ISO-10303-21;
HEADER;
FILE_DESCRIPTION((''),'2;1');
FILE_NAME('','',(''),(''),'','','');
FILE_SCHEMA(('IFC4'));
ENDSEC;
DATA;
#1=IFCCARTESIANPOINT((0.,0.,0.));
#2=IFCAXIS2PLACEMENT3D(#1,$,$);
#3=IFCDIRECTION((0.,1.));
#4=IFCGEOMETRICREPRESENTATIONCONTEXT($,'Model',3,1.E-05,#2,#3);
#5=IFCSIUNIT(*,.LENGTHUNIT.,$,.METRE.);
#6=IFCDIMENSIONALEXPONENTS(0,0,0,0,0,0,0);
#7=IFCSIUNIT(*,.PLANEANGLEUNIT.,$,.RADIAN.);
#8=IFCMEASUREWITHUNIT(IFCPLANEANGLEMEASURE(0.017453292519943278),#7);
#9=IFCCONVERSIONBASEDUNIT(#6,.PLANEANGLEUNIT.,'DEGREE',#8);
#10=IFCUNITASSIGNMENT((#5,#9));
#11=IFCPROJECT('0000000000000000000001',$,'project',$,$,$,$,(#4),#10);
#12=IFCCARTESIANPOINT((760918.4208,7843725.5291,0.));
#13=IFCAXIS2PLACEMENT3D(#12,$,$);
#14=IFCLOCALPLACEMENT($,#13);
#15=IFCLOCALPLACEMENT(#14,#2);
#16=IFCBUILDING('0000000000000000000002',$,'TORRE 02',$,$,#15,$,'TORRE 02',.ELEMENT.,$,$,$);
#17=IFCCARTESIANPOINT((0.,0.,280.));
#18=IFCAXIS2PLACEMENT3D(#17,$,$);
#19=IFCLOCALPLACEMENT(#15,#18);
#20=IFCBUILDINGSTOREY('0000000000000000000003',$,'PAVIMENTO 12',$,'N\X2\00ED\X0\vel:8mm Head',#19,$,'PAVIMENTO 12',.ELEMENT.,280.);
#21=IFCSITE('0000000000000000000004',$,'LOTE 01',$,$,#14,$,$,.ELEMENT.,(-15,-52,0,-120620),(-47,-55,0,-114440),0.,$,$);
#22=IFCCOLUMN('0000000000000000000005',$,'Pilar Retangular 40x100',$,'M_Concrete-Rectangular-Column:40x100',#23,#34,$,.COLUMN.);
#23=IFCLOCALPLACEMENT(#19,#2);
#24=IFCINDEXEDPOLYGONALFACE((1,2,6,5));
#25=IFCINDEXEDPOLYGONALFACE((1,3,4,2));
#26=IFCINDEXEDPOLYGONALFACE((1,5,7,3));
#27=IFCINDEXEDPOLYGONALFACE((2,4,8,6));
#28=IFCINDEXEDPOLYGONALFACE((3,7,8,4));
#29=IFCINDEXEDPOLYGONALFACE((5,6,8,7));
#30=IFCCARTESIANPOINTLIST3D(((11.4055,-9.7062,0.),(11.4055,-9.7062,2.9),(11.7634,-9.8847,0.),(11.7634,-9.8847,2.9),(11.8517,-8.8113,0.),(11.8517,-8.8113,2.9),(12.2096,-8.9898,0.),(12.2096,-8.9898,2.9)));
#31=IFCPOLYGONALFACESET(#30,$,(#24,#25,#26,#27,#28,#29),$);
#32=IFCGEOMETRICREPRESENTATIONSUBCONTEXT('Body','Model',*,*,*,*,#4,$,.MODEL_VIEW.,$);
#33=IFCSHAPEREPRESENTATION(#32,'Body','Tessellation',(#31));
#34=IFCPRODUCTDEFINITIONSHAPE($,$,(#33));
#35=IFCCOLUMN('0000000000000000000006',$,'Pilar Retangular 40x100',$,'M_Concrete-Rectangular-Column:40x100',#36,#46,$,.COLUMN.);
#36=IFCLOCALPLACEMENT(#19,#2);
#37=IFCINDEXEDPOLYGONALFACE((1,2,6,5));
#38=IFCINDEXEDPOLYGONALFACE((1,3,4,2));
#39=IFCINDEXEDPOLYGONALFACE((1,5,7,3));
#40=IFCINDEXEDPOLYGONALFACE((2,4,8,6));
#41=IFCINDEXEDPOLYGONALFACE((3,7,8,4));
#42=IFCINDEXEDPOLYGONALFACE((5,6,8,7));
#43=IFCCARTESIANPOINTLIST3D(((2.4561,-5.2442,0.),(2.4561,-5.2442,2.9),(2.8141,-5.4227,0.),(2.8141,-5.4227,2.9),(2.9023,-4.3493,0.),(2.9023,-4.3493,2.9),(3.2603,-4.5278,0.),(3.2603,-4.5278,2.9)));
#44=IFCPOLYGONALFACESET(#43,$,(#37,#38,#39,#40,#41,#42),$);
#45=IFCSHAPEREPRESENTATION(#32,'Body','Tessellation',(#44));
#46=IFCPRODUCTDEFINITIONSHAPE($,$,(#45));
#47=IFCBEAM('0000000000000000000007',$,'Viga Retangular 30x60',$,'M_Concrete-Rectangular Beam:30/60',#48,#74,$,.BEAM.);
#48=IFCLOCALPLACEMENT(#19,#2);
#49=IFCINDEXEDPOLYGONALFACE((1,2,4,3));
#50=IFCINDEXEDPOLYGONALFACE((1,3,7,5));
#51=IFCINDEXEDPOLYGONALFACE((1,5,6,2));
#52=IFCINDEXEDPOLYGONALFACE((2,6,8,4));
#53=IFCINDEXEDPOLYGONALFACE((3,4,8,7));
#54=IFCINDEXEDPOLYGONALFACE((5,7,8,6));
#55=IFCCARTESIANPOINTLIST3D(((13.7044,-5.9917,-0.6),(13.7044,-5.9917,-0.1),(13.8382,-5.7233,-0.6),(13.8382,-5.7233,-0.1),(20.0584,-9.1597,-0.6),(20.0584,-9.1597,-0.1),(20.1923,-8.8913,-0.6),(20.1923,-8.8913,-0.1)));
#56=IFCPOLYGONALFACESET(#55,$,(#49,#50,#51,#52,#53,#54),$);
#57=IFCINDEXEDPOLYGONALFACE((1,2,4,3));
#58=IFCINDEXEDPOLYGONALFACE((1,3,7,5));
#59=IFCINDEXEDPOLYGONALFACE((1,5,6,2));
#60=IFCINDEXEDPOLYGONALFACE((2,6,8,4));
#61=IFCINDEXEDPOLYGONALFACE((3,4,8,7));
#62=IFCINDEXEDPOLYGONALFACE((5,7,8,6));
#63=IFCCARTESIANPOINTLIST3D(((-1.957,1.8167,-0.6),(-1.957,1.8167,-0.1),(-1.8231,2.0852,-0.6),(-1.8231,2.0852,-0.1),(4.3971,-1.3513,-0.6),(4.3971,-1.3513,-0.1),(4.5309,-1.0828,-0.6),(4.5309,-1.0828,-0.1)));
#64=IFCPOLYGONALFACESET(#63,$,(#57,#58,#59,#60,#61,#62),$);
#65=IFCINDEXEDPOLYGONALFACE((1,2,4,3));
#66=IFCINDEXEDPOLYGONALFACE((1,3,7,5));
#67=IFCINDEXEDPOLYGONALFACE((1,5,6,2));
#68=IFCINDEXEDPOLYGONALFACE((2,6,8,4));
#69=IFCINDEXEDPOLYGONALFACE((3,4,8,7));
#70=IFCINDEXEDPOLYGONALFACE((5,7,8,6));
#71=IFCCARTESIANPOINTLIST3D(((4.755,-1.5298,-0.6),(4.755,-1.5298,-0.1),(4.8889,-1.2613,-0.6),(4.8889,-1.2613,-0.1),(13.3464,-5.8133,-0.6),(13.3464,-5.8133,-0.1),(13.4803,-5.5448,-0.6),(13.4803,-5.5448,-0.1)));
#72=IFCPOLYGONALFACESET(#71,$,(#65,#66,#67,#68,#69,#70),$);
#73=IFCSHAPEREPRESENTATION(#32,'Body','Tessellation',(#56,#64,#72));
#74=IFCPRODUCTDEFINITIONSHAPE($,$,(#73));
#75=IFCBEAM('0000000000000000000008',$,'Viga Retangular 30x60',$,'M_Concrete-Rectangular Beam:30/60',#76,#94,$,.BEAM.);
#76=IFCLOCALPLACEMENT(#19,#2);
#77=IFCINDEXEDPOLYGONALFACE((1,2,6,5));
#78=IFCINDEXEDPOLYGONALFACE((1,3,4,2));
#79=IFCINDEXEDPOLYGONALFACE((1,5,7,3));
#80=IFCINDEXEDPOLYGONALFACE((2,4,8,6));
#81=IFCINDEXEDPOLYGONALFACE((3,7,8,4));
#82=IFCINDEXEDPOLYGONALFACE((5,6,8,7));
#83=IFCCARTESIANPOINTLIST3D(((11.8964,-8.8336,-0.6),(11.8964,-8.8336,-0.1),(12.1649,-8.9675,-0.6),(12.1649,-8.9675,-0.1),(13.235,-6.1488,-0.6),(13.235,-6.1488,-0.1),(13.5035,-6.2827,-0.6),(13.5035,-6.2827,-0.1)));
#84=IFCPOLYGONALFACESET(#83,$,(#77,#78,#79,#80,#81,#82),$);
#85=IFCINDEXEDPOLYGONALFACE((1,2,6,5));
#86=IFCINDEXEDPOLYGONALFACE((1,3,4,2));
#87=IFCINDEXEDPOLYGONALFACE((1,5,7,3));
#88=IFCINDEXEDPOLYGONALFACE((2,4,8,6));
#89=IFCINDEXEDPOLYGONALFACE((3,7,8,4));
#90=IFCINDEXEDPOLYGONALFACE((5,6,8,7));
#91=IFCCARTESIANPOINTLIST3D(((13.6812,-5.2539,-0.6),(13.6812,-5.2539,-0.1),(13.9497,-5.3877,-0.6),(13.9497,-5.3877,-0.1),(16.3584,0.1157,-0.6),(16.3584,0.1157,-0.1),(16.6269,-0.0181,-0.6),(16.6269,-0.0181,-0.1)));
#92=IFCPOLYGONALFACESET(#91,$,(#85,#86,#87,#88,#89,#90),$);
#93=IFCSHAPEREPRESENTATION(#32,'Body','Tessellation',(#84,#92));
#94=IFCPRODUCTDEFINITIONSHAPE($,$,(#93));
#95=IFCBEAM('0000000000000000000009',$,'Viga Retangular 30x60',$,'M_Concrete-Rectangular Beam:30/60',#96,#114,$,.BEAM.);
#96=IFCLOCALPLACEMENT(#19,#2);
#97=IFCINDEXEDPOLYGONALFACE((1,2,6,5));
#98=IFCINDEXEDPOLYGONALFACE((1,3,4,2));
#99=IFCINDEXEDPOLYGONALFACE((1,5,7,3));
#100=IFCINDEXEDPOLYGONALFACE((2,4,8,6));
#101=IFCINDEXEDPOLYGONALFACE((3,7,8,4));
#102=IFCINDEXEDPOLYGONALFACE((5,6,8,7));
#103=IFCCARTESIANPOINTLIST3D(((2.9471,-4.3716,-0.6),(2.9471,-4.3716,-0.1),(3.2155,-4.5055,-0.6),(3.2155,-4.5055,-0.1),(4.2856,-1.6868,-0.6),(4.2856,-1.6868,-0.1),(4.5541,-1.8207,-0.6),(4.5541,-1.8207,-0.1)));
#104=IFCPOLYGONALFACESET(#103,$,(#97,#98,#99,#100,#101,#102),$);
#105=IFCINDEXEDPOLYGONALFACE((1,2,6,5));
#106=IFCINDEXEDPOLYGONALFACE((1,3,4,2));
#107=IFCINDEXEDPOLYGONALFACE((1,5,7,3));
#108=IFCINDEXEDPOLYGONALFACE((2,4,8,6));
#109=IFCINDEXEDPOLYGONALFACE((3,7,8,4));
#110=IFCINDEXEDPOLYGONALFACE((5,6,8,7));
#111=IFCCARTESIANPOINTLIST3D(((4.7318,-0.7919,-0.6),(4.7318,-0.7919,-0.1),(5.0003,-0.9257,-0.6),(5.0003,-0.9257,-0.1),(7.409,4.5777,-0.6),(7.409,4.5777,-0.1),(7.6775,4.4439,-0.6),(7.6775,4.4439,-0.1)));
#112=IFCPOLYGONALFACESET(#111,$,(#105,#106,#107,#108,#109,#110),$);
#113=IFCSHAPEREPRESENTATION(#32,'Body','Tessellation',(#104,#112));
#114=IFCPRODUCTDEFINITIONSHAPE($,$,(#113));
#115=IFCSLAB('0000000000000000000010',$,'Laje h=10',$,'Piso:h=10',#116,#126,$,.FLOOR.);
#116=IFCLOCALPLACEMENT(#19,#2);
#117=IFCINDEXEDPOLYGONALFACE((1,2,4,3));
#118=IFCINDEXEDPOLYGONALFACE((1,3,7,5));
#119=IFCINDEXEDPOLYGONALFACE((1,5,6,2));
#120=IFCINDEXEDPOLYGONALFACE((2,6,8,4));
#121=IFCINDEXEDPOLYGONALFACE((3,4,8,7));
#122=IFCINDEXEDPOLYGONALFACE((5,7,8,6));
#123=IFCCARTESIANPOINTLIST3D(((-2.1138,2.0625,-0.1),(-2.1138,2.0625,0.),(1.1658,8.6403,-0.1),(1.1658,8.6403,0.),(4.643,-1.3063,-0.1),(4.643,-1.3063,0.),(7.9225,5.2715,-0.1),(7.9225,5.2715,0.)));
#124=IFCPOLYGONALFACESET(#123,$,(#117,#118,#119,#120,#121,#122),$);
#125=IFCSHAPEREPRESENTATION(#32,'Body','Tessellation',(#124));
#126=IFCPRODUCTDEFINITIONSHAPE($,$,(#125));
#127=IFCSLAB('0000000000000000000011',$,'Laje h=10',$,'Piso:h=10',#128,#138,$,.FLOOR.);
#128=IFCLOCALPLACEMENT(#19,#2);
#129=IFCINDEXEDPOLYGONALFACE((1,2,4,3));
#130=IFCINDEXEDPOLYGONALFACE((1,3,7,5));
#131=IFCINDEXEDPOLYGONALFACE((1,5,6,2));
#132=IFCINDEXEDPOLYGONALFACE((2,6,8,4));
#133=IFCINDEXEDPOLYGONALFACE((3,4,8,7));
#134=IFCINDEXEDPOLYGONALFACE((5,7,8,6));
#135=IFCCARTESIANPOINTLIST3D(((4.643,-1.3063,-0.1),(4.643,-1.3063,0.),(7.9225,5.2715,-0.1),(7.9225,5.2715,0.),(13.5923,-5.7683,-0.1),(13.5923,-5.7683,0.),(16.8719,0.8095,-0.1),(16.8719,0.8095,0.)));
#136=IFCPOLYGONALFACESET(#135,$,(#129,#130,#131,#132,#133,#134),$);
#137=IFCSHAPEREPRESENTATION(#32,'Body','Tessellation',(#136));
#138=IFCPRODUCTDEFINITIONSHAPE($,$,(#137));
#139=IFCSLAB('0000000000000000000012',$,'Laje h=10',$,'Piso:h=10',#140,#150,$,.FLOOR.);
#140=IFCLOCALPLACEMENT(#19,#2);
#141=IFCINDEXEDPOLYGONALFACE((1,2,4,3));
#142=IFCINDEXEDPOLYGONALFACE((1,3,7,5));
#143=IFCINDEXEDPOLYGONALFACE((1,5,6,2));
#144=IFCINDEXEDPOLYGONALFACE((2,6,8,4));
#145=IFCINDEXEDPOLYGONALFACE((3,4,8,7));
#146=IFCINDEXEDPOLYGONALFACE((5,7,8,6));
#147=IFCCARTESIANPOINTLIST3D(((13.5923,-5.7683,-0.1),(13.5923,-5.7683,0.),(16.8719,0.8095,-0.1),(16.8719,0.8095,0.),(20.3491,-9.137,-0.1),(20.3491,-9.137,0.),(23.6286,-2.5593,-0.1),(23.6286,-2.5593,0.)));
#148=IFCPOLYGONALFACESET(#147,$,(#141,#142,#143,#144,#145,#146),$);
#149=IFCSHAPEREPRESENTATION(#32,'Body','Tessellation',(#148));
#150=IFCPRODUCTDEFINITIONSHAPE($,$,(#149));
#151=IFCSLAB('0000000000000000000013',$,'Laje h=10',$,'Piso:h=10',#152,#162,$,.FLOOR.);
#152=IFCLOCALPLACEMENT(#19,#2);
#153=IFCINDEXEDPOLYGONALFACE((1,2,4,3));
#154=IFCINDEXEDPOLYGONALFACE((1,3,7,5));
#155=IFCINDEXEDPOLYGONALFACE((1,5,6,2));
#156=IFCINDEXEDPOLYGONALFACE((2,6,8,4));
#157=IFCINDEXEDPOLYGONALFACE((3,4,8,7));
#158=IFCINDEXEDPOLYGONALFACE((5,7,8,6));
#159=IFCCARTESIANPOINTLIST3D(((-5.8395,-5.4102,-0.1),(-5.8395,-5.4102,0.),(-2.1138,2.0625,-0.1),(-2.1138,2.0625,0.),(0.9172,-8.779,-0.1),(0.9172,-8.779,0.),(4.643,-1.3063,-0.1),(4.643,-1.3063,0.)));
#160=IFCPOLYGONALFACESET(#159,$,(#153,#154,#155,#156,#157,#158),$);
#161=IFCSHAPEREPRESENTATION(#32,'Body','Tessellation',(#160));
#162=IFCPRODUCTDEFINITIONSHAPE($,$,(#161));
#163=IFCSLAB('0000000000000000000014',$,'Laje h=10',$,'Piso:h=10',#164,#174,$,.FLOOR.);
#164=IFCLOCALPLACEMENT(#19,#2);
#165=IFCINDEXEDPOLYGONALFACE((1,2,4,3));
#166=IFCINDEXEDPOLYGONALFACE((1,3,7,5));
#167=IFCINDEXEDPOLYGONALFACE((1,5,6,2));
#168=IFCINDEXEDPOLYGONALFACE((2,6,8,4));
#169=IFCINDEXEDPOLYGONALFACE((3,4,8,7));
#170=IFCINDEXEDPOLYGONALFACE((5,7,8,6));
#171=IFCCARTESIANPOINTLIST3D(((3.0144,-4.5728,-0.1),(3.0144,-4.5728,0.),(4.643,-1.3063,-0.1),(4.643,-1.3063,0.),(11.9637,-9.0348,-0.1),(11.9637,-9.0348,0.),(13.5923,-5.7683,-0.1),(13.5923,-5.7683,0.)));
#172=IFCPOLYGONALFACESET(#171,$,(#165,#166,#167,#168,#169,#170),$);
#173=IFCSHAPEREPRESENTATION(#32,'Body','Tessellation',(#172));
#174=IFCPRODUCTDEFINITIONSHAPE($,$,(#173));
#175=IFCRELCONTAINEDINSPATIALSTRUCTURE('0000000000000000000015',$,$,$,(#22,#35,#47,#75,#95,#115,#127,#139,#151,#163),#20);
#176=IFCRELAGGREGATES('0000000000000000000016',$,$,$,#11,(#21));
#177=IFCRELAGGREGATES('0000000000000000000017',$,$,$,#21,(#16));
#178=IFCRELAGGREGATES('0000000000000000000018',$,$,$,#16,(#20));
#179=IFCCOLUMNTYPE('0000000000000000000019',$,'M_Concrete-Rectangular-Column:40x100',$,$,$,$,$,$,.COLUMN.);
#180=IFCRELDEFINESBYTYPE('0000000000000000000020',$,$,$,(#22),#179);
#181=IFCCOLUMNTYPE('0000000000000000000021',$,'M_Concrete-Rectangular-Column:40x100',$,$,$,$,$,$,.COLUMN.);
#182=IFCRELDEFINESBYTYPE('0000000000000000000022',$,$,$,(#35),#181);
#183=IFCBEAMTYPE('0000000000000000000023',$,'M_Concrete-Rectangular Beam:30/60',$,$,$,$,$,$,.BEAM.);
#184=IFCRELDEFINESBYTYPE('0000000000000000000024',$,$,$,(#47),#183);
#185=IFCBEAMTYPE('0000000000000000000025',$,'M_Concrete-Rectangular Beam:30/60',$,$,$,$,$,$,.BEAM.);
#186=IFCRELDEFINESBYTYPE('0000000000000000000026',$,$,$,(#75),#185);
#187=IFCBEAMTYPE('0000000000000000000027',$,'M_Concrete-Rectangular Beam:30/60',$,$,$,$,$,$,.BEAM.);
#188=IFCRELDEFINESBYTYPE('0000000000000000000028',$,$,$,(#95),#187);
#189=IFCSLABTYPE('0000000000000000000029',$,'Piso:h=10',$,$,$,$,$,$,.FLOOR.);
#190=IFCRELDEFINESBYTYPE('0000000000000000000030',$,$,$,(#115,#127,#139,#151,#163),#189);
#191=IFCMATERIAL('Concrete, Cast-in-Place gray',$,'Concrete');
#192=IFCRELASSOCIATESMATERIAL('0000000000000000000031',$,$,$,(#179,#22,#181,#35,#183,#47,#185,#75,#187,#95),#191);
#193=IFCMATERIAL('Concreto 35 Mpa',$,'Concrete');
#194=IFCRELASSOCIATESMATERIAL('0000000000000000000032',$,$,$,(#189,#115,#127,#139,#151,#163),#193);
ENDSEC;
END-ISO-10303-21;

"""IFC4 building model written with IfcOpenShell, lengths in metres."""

from ifc_helpers import new_model, entity, si_unit, converted_unit, direction, frame, origin, place, context, subcontext, project, spatial, indexed_curve, outline, extrude, source, transform, mapped, material, type_object, type_shapes, element, save


model = new_model("IFC4")

# Units and contexts
model_context = context("Model", 3, precision=1e-05, world=origin(), true_north=direction((0.0, 1.0)))
body_context = subcontext(model_context, "Body", "Model", "MODEL_VIEW")
ifc_project = project(units=[si_unit("LENGTHUNIT", "METRE"), converted_unit("PLANEANGLEUNIT", "DEGREE", entity("IfcPlaneAngleMeasure", 0.017453292519943278), si_unit("PLANEANGLEUNIT", "RADIAN"), dimensions=[0, 0, 0, 0, 0, 0, 0])], contexts=[model_context])

# Site, building, storey
site_placement = place(None, frame((760918.4208, 7843725.5291, 0.0)))
site = spatial("IfcSite", under=ifc_project, at=site_placement, Name="LOTE 01", CompositionType="ELEMENT", RefLatitude=(-15, -52, 0, -120620), RefLongitude=(-47, -55, 0, -114440), RefElevation=0.0)
building_placement = place(site_placement, origin())
building = spatial("IfcBuilding", under=site, at=building_placement, Name="TORRE 02", LongName="TORRE 02", CompositionType="ELEMENT")
storey_placement = place(building_placement, frame((0.0, 0.0, 280.0)))
storey = spatial("IfcBuildingStorey", under=building, at=storey_placement, Name="PAVIMENTO 12", ObjectType="Nível:8mm Head", LongName="PAVIMENTO 12", CompositionType="ELEMENT", Elevation=280.0)

# Columns
ifc_material_1 = material(Name="Concrete, Cast-in-Place gray", Category="Concrete")
column_type_1 = type_object("IfcColumnType", Name="M_Concrete-Rectangular-Column:40x100", PredefinedType="COLUMN", material=ifc_material_1)
shared_shape_1 = source(origin(), body_context, "Body", "SweptSolid", [
    extrude(outline(indexed_curve([(-1.45, -0.2), (1.45, -0.2), (1.45, 0.2), (-1.45, 0.2), (-1.45, -0.2)], self_intersect=False)), frame((11.5844, -9.7955, 281.45), z_axis=(0.446198, 0.894934, 0.0), x_axis=(0.0, 0.0, 1.0)), (0.0, 0.0, 1.0), 1.0),
])
type_shapes(column_type_1, [shared_shape_1])
column_1_placement = place(storey_placement, frame((0.0, 0.0, -280.0)))
element("IfcColumn", 1, at=column_1_placement, inside=storey, type_object=column_type_1, material=ifc_material_1, Name="Pilar Retangular 40x100", ObjectType="M_Concrete-Rectangular-Column:40x100", PredefinedType="COLUMN", context=body_context, shape_type="MappedRepresentation", body=[
    mapped(shared_shape_1, transform((0.0, 0.0, 0.0), scale=1.0)),
])
column_type_2 = type_object("IfcColumnType", Name="M_Concrete-Rectangular-Column:40x100", PredefinedType="COLUMN", material=ifc_material_1)
shared_shape_2 = source(origin(), body_context, "Body", "SweptSolid", [
    extrude(outline(indexed_curve([(-1.45, -0.2), (1.45, -0.2), (1.45, 0.2), (-1.45, 0.2), (-1.45, -0.2)], self_intersect=False)), frame((2.6351, -5.3335, 281.45), z_axis=(0.446198, 0.894934, 0.0), x_axis=(0.0, 0.0, 1.0)), (0.0, 0.0, 1.0), 1.0),
])
type_shapes(column_type_2, [shared_shape_2])
column_2_placement = place(storey_placement, frame((0.0, 0.0, -280.0)))
element("IfcColumn", 2, at=column_2_placement, inside=storey, type_object=column_type_2, material=ifc_material_1, Name="Pilar Retangular 40x100", ObjectType="M_Concrete-Rectangular-Column:40x100", PredefinedType="COLUMN", context=body_context, shape_type="MappedRepresentation", body=[
    mapped(shared_shape_2, transform((0.0, 0.0, 0.0), scale=1.0)),
])

# Beams
beam_type_1 = type_object("IfcBeamType", Name="M_Concrete-Rectangular Beam:30/60", PredefinedType="BEAM", material=ifc_material_1)
shared_shape_3 = source(origin(), body_context, "Body", "SweptSolid", [
    extrude(outline(indexed_curve([(-0.25, -0.15), (0.25, -0.15), (0.25, 0.15), (-0.25, 0.15), (-0.25, -0.15)], self_intersect=False)), frame((13.7713, -5.8575, 279.65), z_axis=(0.894934, -0.446198, 0.0), x_axis=(0.0, 0.0, -1.0)), (0.0, 0.0, 1.0), 7.1),
    extrude(outline(indexed_curve([(-0.25, -0.15), (0.25, -0.15), (0.25, 0.15), (-0.25, 0.15), (-0.25, -0.15)], self_intersect=False)), frame((-1.89, 1.951, 279.65), z_axis=(0.894934, -0.446198, 0.0), x_axis=(0.0, 0.0, -1.0)), (0.0, 0.0, 1.0), 7.1),
    extrude(outline(indexed_curve([(-0.25, -0.15), (0.25, -0.15), (0.25, 0.15), (-0.25, 0.15), (-0.25, -0.15)], self_intersect=False)), frame((4.822, -1.3955, 279.65), z_axis=(0.894934, -0.446198, 0.0), x_axis=(0.0, 0.0, -1.0)), (0.0, 0.0, 1.0), 9.6),
])
type_shapes(beam_type_1, [shared_shape_3])
beam_1_placement = place(storey_placement, frame((0.0, 0.0, -280.0)))
element("IfcBeam", 3, at=beam_1_placement, inside=storey, type_object=beam_type_1, material=ifc_material_1, Name="Viga Retangular 30x60", ObjectType="M_Concrete-Rectangular Beam:30/60", PredefinedType="BEAM", context=body_context, shape_type="MappedRepresentation", body=[
    mapped(shared_shape_3, transform((0.0, 0.0, 0.0), scale=1.0)),
])
beam_type_2 = type_object("IfcBeamType", Name="M_Concrete-Rectangular Beam:30/60", PredefinedType="BEAM", material=ifc_material_1)
shared_shape_4 = source(origin(), body_context, "Body", "SweptSolid", [
    extrude(outline(indexed_curve([(-0.25, -0.15), (0.25, -0.15), (0.25, 0.15), (-0.25, 0.15), (-0.25, -0.15)], self_intersect=False)), frame((12.0306, -8.9005, 279.65), z_axis=(0.446198, 0.894934, 0.0), x_axis=(0.0, 0.0, 1.0)), (0.0, 0.0, 1.0), 3.0),
    extrude(outline(indexed_curve([(-0.25, -0.15), (0.25, -0.15), (0.25, 0.15), (-0.25, 0.15), (-0.25, -0.15)], self_intersect=False)), frame((13.8154, -5.3208, 279.65), z_axis=(0.446198, 0.894934, 0.0), x_axis=(0.0, 0.0, 1.0)), (0.0, 0.0, 1.0), 6.0),
])
type_shapes(beam_type_2, [shared_shape_4])
beam_2_placement = place(storey_placement, frame((0.0, 0.0, -280.0)))
element("IfcBeam", 4, at=beam_2_placement, inside=storey, type_object=beam_type_2, material=ifc_material_1, Name="Viga Retangular 30x60", ObjectType="M_Concrete-Rectangular Beam:30/60", PredefinedType="BEAM", context=body_context, shape_type="MappedRepresentation", body=[
    mapped(shared_shape_4, transform((0.0, 0.0, 0.0), scale=1.0)),
])
beam_type_3 = type_object("IfcBeamType", Name="M_Concrete-Rectangular Beam:30/60", PredefinedType="BEAM", material=ifc_material_1)
shared_shape_5 = source(origin(), body_context, "Body", "SweptSolid", [
    extrude(outline(indexed_curve([(-0.25, -0.15), (0.25, -0.15), (0.25, 0.15), (-0.25, 0.15), (-0.25, -0.15)], self_intersect=False)), frame((3.0813, -4.4385, 279.65), z_axis=(0.446198, 0.894934, 0.0), x_axis=(0.0, 0.0, 1.0)), (0.0, 0.0, 1.0), 3.0),
    extrude(outline(indexed_curve([(-0.25, -0.15), (0.25, -0.15), (0.25, 0.15), (-0.25, 0.15), (-0.25, -0.15)], self_intersect=False)), frame((4.8661, -0.8588, 279.65), z_axis=(0.446198, 0.894934, 0.0), x_axis=(0.0, 0.0, 1.0)), (0.0, 0.0, 1.0), 6.0),
])
type_shapes(beam_type_3, [shared_shape_5])
beam_3_placement = place(storey_placement, frame((0.0, 0.0, -280.0)))
element("IfcBeam", 5, at=beam_3_placement, inside=storey, type_object=beam_type_3, material=ifc_material_1, Name="Viga Retangular 30x60", ObjectType="M_Concrete-Rectangular Beam:30/60", PredefinedType="BEAM", context=body_context, shape_type="MappedRepresentation", body=[
    mapped(shared_shape_5, transform((0.0, 0.0, 0.0), scale=1.0)),
])

# Slabs
ifc_material_2 = material(Name="Concreto 35 Mpa", Category="Concrete")
slab_type = type_object("IfcSlabType", Name="Piso:h=10", PredefinedType="FLOOR", material=ifc_material_2)
slab_1_placement = place(storey_placement, origin())
element("IfcSlab", 6, at=slab_1_placement, inside=storey, type_object=slab_type, material=ifc_material_2, Name="Laje h=10", ObjectType="Piso:h=10", PredefinedType="FLOOR", context=body_context, shape_type="SweptSolid", body=[
    extrude(outline(indexed_curve([(-3.675, -3.775), (3.675, -3.775), (3.675, 3.775), (-3.675, 3.775), (-3.675, -3.775)], self_intersect=False)), frame((2.9044, 3.667, 0.0), z_axis=(0.0, 0.0, -1.0), x_axis=(-0.446198, -0.894934, 0.0)), (0.0, 0.0, 1.0), 0.1),
])
slab_2_placement = place(storey_placement, origin())
element("IfcSlab", 7, at=slab_2_placement, inside=storey, type_object=slab_type, material=ifc_material_2, Name="Laje h=10", ObjectType="Piso:h=10", PredefinedType="FLOOR", context=body_context, shape_type="SweptSolid", body=[
    extrude(outline(indexed_curve([(-3.675, -5.0), (3.675, -5.0), (3.675, 5.0), (-3.675, 5.0), (-3.675, -5.0)], self_intersect=False)), frame((10.7574, -0.2484, 0.0), z_axis=(0.0, 0.0, -1.0), x_axis=(-0.446198, -0.894934, 0.0)), (0.0, 0.0, 1.0), 0.1),
])
slab_3_placement = place(storey_placement, origin())
element("IfcSlab", 8, at=slab_3_placement, inside=storey, type_object=slab_type, material=ifc_material_2, Name="Laje h=10", ObjectType="Piso:h=10", PredefinedType="FLOOR", context=body_context, shape_type="SweptSolid", body=[
    extrude(outline(indexed_curve([(-3.675, -3.775), (3.675, -3.775), (3.675, 3.775), (-3.675, 3.775), (-3.675, -3.775)], self_intersect=False)), frame((18.6105, -4.1638, 0.0), z_axis=(0.0, 0.0, -1.0), x_axis=(-0.446198, -0.894934, 0.0)), (0.0, 0.0, 1.0), 0.1),
])
slab_4_placement = place(storey_placement, origin())
element("IfcSlab", 9, at=slab_4_placement, inside=storey, type_object=slab_type, material=ifc_material_2, Name="Laje h=10", ObjectType="Piso:h=10", PredefinedType="FLOOR", context=body_context, shape_type="SweptSolid", body=[
    extrude(outline(indexed_curve([(-4.175, -3.775), (4.175, -3.775), (4.175, 3.775), (-4.175, 3.775), (-4.175, -3.775)], self_intersect=False)), frame((-0.5983, -3.3582, 0.0), z_axis=(0.0, 0.0, -1.0), x_axis=(-0.446198, -0.894934, 0.0)), (0.0, 0.0, 1.0), 0.1),
])
slab_5_placement = place(storey_placement, origin())
element("IfcSlab", 10, at=slab_5_placement, inside=storey, type_object=slab_type, material=ifc_material_2, Name="Laje h=10", ObjectType="Piso:h=10", PredefinedType="FLOOR", context=body_context, shape_type="SweptSolid", body=[
    extrude(outline(indexed_curve([(-1.825, -5.0), (1.825, -5.0), (1.825, 5.0), (-1.825, 5.0), (-1.825, -5.0)], self_intersect=False)), frame((8.3033, -5.1705, 0.0), z_axis=(0.0, 0.0, -1.0), x_axis=(-0.446198, -0.894934, 0.0)), (0.0, 0.0, 1.0), 0.1),
])

save(model, "model.ifc")
